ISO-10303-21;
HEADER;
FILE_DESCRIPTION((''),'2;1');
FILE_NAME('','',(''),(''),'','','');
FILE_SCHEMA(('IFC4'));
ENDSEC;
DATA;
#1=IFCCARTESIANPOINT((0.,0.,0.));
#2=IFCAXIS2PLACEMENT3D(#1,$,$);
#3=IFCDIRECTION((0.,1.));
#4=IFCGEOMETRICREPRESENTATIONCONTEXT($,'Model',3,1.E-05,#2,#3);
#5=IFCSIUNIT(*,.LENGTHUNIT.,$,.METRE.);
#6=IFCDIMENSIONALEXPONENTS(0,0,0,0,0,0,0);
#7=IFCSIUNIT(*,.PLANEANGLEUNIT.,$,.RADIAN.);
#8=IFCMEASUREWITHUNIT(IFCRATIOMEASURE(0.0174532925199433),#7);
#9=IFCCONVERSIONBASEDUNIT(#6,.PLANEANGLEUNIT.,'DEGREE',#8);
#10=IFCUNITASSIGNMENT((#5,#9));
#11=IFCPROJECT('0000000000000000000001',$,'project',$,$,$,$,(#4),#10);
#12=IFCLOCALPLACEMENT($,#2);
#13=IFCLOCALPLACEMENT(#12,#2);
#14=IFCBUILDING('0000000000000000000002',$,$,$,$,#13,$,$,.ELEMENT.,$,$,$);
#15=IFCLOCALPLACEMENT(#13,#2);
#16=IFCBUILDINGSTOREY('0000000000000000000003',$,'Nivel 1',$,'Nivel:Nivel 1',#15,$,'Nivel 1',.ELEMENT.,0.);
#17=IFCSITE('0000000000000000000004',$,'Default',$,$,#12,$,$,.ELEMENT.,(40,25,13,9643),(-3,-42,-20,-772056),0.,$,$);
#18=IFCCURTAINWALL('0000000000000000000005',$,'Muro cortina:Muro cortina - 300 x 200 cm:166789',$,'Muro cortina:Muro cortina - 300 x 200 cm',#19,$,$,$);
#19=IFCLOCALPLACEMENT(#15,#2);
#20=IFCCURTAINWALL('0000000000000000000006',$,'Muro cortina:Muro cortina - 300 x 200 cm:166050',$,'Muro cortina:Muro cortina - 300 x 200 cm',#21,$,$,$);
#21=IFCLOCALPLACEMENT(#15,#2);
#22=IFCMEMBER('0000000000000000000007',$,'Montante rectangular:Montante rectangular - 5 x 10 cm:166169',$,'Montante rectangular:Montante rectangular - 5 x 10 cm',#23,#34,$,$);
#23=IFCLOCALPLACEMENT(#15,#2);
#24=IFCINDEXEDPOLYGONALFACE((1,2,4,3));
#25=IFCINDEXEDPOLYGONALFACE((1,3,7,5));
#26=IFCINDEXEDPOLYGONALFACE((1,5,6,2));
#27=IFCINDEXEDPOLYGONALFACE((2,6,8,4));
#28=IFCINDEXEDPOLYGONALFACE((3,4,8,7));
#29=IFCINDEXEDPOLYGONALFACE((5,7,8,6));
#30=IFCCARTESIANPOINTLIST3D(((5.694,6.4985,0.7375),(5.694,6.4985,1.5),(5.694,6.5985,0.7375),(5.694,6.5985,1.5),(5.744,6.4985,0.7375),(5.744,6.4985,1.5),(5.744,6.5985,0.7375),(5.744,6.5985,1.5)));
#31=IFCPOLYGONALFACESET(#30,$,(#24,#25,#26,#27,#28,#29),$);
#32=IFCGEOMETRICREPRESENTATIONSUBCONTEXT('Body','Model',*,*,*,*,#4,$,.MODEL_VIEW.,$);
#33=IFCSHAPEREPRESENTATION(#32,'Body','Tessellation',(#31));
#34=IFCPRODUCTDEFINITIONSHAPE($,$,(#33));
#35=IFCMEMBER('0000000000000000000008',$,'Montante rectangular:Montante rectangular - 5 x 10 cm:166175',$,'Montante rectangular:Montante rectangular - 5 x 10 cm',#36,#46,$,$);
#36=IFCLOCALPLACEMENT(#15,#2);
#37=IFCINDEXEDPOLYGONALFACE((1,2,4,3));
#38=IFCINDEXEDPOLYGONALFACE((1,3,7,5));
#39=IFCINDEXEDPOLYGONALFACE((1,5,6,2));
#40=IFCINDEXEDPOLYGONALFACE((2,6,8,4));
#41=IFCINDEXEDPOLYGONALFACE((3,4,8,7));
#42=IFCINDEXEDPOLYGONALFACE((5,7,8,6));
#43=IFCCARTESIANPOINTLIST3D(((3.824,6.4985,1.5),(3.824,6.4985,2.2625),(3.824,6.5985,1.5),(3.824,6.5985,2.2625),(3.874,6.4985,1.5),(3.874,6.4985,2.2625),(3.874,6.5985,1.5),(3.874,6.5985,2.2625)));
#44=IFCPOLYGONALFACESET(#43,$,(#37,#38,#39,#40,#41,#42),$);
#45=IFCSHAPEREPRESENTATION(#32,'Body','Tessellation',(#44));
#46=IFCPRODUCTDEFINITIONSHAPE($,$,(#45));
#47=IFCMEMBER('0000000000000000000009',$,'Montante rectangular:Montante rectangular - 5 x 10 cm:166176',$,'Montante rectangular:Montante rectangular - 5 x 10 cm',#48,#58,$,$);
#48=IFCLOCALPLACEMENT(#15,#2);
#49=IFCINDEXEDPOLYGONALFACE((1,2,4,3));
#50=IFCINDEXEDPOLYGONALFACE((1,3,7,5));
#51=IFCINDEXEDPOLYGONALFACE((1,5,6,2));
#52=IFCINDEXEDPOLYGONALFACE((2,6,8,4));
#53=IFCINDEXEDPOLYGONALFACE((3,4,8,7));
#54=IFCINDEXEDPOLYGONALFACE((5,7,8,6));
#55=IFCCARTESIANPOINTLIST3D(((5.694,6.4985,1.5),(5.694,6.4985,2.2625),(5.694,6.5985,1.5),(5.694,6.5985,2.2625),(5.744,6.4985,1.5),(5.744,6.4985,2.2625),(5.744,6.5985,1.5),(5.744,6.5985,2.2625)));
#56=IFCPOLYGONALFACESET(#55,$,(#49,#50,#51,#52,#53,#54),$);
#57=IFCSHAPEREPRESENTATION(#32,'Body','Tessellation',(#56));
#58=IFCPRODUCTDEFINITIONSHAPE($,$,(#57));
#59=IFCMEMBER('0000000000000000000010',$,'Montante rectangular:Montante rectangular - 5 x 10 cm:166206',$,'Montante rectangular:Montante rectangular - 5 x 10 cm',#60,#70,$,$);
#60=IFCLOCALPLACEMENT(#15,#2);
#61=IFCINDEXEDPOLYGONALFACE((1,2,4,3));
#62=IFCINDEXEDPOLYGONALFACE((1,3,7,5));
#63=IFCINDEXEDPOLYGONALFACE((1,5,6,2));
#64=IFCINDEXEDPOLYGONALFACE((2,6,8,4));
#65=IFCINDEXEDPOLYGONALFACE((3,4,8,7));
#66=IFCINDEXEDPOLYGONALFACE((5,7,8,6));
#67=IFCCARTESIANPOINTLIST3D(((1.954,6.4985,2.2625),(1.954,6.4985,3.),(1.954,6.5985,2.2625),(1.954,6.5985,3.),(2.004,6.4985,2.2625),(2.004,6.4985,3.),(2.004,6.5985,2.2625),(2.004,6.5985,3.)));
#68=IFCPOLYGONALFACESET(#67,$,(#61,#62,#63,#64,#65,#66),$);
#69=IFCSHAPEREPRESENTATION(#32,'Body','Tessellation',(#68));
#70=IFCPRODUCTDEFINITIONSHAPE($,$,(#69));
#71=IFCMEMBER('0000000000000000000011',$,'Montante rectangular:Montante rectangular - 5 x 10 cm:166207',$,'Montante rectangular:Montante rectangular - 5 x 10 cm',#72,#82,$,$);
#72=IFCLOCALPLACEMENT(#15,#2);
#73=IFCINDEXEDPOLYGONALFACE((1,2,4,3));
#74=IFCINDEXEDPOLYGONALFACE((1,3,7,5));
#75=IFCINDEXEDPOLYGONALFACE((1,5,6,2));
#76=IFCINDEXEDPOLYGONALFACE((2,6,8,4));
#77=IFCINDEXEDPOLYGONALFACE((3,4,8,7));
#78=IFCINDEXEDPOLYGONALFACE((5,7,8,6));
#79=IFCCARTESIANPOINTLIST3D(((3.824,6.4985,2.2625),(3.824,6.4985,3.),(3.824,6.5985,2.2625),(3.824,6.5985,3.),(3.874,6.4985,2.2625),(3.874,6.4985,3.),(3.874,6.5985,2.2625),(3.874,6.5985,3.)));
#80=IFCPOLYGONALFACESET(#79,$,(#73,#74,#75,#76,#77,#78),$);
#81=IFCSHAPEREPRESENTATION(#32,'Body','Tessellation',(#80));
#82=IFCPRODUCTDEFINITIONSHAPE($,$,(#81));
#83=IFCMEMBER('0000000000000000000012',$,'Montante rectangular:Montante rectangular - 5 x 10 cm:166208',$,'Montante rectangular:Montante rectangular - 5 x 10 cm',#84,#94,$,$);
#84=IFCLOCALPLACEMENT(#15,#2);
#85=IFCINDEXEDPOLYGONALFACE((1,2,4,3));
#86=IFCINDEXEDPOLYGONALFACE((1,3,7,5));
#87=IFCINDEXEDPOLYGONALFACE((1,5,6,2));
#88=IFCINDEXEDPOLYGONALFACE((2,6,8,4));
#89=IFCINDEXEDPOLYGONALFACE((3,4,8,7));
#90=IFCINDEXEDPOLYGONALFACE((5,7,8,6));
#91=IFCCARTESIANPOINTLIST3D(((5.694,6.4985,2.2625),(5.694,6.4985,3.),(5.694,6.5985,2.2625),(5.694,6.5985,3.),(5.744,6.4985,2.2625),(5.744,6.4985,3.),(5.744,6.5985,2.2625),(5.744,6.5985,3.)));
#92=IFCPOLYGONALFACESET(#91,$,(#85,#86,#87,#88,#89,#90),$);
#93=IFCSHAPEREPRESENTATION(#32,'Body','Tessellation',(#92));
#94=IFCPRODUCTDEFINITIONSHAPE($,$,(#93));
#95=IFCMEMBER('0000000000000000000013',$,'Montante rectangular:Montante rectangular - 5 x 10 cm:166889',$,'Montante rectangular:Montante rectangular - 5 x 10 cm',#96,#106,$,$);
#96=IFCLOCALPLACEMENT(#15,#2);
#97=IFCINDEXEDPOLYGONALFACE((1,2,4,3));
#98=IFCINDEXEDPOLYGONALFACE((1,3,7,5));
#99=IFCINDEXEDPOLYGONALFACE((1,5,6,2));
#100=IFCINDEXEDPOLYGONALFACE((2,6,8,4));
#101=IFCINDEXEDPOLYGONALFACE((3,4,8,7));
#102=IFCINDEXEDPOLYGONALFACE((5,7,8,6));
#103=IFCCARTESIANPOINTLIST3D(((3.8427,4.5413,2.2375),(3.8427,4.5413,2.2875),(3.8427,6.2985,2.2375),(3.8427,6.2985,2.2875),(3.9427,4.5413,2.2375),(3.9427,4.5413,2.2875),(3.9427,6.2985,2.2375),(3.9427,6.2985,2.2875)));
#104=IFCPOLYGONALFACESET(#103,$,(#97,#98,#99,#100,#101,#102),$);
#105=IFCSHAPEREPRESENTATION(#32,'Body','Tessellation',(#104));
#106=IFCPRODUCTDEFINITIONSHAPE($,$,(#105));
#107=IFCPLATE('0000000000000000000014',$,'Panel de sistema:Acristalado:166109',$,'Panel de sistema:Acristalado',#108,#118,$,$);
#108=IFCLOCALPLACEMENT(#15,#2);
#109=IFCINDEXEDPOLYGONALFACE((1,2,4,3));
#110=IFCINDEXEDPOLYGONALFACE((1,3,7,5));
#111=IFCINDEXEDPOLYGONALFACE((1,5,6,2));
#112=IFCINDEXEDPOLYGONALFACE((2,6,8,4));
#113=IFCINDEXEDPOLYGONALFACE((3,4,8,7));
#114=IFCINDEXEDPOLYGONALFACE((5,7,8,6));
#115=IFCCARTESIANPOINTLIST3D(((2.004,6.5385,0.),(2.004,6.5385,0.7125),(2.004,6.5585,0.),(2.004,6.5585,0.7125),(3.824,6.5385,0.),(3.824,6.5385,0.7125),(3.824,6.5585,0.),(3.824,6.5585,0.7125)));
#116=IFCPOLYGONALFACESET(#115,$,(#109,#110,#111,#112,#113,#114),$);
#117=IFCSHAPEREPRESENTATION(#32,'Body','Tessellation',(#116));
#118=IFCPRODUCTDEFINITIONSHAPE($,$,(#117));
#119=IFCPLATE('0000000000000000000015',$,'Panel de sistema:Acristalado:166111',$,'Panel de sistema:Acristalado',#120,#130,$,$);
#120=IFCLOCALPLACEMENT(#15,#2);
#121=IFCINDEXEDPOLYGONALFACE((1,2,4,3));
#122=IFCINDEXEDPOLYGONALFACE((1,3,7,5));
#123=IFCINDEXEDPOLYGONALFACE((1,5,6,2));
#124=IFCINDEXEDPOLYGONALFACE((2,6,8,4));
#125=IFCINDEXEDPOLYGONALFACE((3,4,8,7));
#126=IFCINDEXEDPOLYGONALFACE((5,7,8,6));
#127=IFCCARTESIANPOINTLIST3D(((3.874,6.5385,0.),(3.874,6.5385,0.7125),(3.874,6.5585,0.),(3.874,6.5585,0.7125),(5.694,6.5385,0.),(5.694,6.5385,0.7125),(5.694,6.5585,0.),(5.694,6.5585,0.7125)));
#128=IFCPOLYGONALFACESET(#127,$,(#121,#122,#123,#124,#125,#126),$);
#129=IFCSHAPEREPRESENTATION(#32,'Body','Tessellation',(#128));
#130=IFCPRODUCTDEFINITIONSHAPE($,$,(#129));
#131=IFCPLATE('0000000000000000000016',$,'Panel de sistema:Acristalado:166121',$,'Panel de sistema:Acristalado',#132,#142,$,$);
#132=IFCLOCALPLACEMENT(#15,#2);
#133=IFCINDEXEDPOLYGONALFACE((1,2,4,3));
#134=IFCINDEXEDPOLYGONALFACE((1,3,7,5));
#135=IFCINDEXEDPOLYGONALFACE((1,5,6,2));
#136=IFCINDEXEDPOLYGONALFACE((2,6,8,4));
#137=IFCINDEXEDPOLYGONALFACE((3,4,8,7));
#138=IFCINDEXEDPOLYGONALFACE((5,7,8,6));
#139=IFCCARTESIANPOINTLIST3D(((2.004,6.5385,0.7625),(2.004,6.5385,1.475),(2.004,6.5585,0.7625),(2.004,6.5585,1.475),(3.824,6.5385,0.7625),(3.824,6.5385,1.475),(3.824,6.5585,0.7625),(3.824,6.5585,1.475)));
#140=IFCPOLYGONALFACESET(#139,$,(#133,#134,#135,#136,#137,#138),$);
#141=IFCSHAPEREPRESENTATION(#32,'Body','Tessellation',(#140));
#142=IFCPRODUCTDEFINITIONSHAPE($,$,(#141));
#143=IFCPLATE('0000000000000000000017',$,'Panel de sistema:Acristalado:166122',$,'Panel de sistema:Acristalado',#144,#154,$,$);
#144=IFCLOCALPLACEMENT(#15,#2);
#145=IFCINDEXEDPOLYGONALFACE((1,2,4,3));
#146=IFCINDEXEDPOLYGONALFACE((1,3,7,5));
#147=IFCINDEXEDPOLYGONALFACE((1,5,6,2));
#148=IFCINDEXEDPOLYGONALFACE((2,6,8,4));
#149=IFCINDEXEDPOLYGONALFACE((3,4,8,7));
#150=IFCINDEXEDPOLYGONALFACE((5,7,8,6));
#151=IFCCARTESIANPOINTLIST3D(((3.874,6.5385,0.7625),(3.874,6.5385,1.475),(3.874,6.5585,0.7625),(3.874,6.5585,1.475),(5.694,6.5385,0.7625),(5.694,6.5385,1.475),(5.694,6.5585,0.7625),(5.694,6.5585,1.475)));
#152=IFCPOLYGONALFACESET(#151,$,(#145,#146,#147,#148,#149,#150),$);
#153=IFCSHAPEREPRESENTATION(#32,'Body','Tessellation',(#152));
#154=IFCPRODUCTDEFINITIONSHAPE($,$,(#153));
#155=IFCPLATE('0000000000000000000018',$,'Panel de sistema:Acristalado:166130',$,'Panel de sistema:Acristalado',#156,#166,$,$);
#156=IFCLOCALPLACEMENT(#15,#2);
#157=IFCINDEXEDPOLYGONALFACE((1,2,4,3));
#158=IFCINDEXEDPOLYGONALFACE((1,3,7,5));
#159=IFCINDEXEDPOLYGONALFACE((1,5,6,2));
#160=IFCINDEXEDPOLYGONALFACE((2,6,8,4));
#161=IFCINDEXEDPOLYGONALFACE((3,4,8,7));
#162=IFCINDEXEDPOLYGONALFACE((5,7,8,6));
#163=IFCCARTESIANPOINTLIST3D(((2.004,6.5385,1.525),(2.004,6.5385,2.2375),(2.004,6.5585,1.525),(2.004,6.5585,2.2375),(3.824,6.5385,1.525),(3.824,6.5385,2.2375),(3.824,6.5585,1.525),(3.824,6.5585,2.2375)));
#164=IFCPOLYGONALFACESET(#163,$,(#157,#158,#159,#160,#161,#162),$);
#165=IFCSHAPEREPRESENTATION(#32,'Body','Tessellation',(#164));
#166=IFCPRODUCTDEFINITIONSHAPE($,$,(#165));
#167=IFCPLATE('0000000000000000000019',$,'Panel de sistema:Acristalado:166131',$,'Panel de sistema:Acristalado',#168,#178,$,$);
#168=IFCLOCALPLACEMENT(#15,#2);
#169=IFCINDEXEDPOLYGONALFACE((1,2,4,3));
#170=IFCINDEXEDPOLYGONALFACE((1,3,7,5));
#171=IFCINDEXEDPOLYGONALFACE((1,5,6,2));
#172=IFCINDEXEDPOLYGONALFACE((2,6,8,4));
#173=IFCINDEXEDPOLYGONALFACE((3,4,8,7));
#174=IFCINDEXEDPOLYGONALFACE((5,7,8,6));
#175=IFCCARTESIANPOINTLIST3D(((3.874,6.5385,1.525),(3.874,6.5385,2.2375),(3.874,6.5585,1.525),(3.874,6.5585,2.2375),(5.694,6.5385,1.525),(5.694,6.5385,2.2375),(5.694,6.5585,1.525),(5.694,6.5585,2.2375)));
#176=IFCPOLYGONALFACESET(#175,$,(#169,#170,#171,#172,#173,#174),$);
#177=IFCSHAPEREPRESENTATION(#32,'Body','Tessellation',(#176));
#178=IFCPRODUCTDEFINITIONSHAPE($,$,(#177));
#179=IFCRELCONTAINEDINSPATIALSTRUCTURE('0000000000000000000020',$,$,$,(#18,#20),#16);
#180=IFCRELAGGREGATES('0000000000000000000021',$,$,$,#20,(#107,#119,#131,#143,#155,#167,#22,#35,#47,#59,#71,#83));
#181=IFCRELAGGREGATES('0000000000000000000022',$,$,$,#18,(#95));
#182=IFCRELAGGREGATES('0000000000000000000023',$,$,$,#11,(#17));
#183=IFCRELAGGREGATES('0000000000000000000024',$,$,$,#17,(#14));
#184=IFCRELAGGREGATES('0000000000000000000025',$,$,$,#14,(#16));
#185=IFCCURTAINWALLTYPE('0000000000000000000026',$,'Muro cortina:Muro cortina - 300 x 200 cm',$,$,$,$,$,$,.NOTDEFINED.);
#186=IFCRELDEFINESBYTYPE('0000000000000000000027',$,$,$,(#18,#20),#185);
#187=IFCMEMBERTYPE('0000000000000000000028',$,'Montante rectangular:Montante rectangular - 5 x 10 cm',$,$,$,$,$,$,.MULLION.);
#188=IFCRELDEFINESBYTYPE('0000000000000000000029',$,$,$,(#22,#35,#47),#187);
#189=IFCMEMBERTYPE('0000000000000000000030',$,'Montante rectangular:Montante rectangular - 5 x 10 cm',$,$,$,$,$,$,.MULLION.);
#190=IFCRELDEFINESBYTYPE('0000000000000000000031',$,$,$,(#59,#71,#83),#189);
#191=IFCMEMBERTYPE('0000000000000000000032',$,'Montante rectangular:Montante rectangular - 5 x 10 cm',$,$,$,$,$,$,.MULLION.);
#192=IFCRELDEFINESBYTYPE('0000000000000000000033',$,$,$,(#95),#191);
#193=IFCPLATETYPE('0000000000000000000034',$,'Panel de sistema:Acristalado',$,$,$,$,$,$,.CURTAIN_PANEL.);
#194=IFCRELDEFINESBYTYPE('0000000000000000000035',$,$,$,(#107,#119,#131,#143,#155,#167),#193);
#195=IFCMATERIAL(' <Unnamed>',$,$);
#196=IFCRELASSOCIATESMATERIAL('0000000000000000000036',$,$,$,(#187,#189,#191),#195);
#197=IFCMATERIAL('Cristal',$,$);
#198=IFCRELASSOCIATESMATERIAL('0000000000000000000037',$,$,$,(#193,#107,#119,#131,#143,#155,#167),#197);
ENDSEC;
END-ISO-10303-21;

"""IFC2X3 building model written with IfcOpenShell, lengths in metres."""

from ifc_helpers import new_model, entity, si_unit, converted_unit, direction, frame, origin, origin_2d_with_axis, place, context, subcontext, project, spatial, rectangle, extrude, source, transform, mapped, material, type_object, type_shapes, element, aggregate, save


model = new_model("IFC2X3")

# Units and contexts
model_context = context("Model", 3, precision=1e-05, world=origin(), true_north=direction((0.0, 1.0)))
body_context = subcontext(model_context, "Body", "Model", "MODEL_VIEW")
ifc_project = project(units=[si_unit("LENGTHUNIT", "METRE"), converted_unit("PLANEANGLEUNIT", "DEGREE", entity("IfcRatioMeasure", 0.0174532925199433), si_unit("PLANEANGLEUNIT", "RADIAN"), dimensions=[0, 0, 0, 0, 0, 0, 0])], contexts=[model_context])

# Site, building, storey
site_placement = place(None, origin())
site = spatial("IfcSite", under=ifc_project, at=site_placement, Name="Default", CompositionType="ELEMENT", RefLatitude=(40, 25, 13, 9643), RefLongitude=(-3, -42, -20, -772056), RefElevation=0.0)
building_placement = place(site_placement, origin())
building = spatial("IfcBuilding", under=site, at=building_placement, CompositionType="ELEMENT")
storey_placement = place(building_placement, origin())
storey = spatial("IfcBuildingStorey", under=building, at=storey_placement, Name="Nivel 1", ObjectType="Nivel:Nivel 1", LongName="Nivel 1", CompositionType="ELEMENT", Elevation=0.0)

# Curtain walls, members
curtain_wall_type = type_object("IfcCurtainWallType", Name="Muro cortina:Muro cortina - 300 x 200 cm", PredefinedType="NOTDEFINED")
curtain_wall_1_placement = place(storey_placement, origin())
curtain_wall_1 = element("IfcCurtainWall", 1, at=curtain_wall_1_placement, inside=storey, type_object=curtain_wall_type, Name="Muro cortina:Muro cortina - 300 x 200 cm:166789", ObjectType="Muro cortina:Muro cortina - 300 x 200 cm")
ifc_material_1 = material(Name=" <Unnamed>")
curtain_wall_2_placement = place(storey_placement, origin())
curtain_wall_2 = element("IfcCurtainWall", 2, at=curtain_wall_2_placement, inside=storey, type_object=curtain_wall_type, Name="Muro cortina:Muro cortina - 300 x 200 cm:166050", ObjectType="Muro cortina:Muro cortina - 300 x 200 cm")
member_type_1 = type_object("IfcMemberType", Name="Montante rectangular:Montante rectangular - 5 x 10 cm", PredefinedType="MULLION", material=ifc_material_1)
shared_shape_1 = source(origin(), body_context, "Body", "SweptSolid", [
    extrude(rectangle(XDim=0.1, YDim=0.05, at=origin_2d_with_axis()), frame((0.0, 0.0, -0.7625), z_axis=(0.0, 0.0, 1.0), x_axis=(0.0, -1.0, 0.0)), (0.0, 0.0, 1.0), 0.7625),
])
type_shapes(member_type_1, [shared_shape_1])
member_1_placement = place(storey_placement, frame((5.719, 6.5485, 0.7375), z_axis=(0.0, 0.0, -1.0), x_axis=(1.0, 0.0, 0.0)))
member_1 = element("IfcMember", 3, at=member_1_placement, type_object=member_type_1, Name="Montante rectangular:Montante rectangular - 5 x 10 cm:166169", ObjectType="Montante rectangular:Montante rectangular - 5 x 10 cm", context=body_context, shape_type="MappedRepresentation", body=[
    mapped(shared_shape_1, transform((0.0, 0.0, 0.0), scale=1.0)),
])
member_2_placement = place(storey_placement, frame((3.849, 6.5485, 1.5), z_axis=(0.0, 0.0, -1.0), x_axis=(1.0, 0.0, 0.0)))
member_2 = element("IfcMember", 4, at=member_2_placement, type_object=member_type_1, Name="Montante rectangular:Montante rectangular - 5 x 10 cm:166175", ObjectType="Montante rectangular:Montante rectangular - 5 x 10 cm", context=body_context, shape_type="MappedRepresentation", body=[
    mapped(shared_shape_1, transform((0.0, 0.0, 0.0), scale=1.0)),
])
member_3_placement = place(storey_placement, frame((5.719, 6.5485, 1.5), z_axis=(0.0, 0.0, -1.0), x_axis=(1.0, 0.0, 0.0)))
member_3 = element("IfcMember", 5, at=member_3_placement, type_object=member_type_1, Name="Montante rectangular:Montante rectangular - 5 x 10 cm:166176", ObjectType="Montante rectangular:Montante rectangular - 5 x 10 cm", context=body_context, shape_type="MappedRepresentation", body=[
    mapped(shared_shape_1, transform((0.0, 0.0, 0.0), scale=1.0)),
])
member_type_2 = type_object("IfcMemberType", Name="Montante rectangular:Montante rectangular - 5 x 10 cm", PredefinedType="MULLION", material=ifc_material_1)
shared_shape_2 = source(origin(), body_context, "Body", "SweptSolid", [
    extrude(rectangle(XDim=0.1, YDim=0.05, at=origin_2d_with_axis()), frame((0.0, 0.0, -0.7375), z_axis=(0.0, 0.0, 1.0), x_axis=(0.0, -1.0, 0.0)), (0.0, 0.0, 1.0), 0.7375),
])
type_shapes(member_type_2, [shared_shape_2])
member_4_placement = place(storey_placement, frame((1.979, 6.5485, 2.2625), z_axis=(0.0, 0.0, -1.0), x_axis=(1.0, 0.0, 0.0)))
member_4 = element("IfcMember", 6, at=member_4_placement, type_object=member_type_2, Name="Montante rectangular:Montante rectangular - 5 x 10 cm:166206", ObjectType="Montante rectangular:Montante rectangular - 5 x 10 cm", context=body_context, shape_type="MappedRepresentation", body=[
    mapped(shared_shape_2, transform((0.0, 0.0, 0.0), scale=1.0)),
])
member_5_placement = place(storey_placement, frame((3.849, 6.5485, 2.2625), z_axis=(0.0, 0.0, -1.0), x_axis=(1.0, 0.0, 0.0)))
member_5 = element("IfcMember", 7, at=member_5_placement, type_object=member_type_2, Name="Montante rectangular:Montante rectangular - 5 x 10 cm:166207", ObjectType="Montante rectangular:Montante rectangular - 5 x 10 cm", context=body_context, shape_type="MappedRepresentation", body=[
    mapped(shared_shape_2, transform((0.0, 0.0, 0.0), scale=1.0)),
])
member_6_placement = place(storey_placement, frame((5.719, 6.5485, 2.2625), z_axis=(0.0, 0.0, -1.0), x_axis=(1.0, 0.0, 0.0)))
member_6 = element("IfcMember", 8, at=member_6_placement, type_object=member_type_2, Name="Montante rectangular:Montante rectangular - 5 x 10 cm:166208", ObjectType="Montante rectangular:Montante rectangular - 5 x 10 cm", context=body_context, shape_type="MappedRepresentation", body=[
    mapped(shared_shape_2, transform((0.0, 0.0, 0.0), scale=1.0)),
])

# Member
member_type_3 = type_object("IfcMemberType", Name="Montante rectangular:Montante rectangular - 5 x 10 cm", PredefinedType="MULLION", material=ifc_material_1)
shared_shape_3 = source(origin(), body_context, "Body", "SweptSolid", [
    extrude(rectangle(XDim=0.1, YDim=0.05, at=origin_2d_with_axis()), frame((0.0, 0.0, -1.7571), z_axis=(0.0, 0.0, 1.0), x_axis=(0.0, -1.0, 0.0)), (0.0, 0.0, 1.0), 1.7571),
])
type_shapes(member_type_3, [shared_shape_3])
member_7_placement = place(storey_placement, frame((3.8927, 4.5413, 2.2625), z_axis=(0.0, -1.0, 0.0), x_axis=(0.0, 0.0, 1.0)))
member_7 = element("IfcMember", 9, at=member_7_placement, type_object=member_type_3, Name="Montante rectangular:Montante rectangular - 5 x 10 cm:166889", ObjectType="Montante rectangular:Montante rectangular - 5 x 10 cm", context=body_context, shape_type="MappedRepresentation", body=[
    mapped(shared_shape_3, transform((0.0, 0.0, 0.0), scale=1.0)),
])

# Plates
ifc_material_2 = material(Name="Cristal")
plate_type_1 = type_object("IfcPlateType", Name="Panel de sistema:Acristalado", PredefinedType="CURTAIN_PANEL", material=ifc_material_2)
shared_shape_4 = source(origin(), body_context, "Body", "SweptSolid", [
    extrude(rectangle(XDim=0.02, YDim=1.82, at=origin_2d_with_axis()), frame((0.0, 0.0, 0.0), z_axis=(0.0, 0.0, 1.0), x_axis=(0.0, 1.0, 0.0)), (0.0, 0.0, 1.0), 0.7125),
])
type_shapes(plate_type_1, [shared_shape_4])
plate_1_placement = place(curtain_wall_2_placement, frame((2.914, 6.5485, 0.0)))
plate_1 = element("IfcPlate", 10, at=plate_1_placement, type_object=plate_type_1, material=ifc_material_2, Name="Panel de sistema:Acristalado:166109", ObjectType="Panel de sistema:Acristalado", context=body_context, shape_type="MappedRepresentation", body=[
    mapped(shared_shape_4, transform((0.0, 0.0, 0.0), scale=1.0)),
])
plate_2_placement = place(curtain_wall_2_placement, frame((4.784, 6.5485, 0.0)))
plate_2 = element("IfcPlate", 11, at=plate_2_placement, type_object=plate_type_1, material=ifc_material_2, Name="Panel de sistema:Acristalado:166111", ObjectType="Panel de sistema:Acristalado", context=body_context, shape_type="MappedRepresentation", body=[
    mapped(shared_shape_4, transform((0.0, 0.0, 0.0), scale=1.0)),
])
plate_3_placement = place(curtain_wall_2_placement, frame((2.914, 6.5485, 0.7625)))
plate_3 = element("IfcPlate", 12, at=plate_3_placement, type_object=plate_type_1, material=ifc_material_2, Name="Panel de sistema:Acristalado:166121", ObjectType="Panel de sistema:Acristalado", context=body_context, shape_type="MappedRepresentation", body=[
    mapped(shared_shape_4, transform((0.0, 0.0, 0.0), scale=1.0)),
])
plate_4_placement = place(curtain_wall_2_placement, frame((4.784, 6.5485, 0.7625)))
plate_4 = element("IfcPlate", 13, at=plate_4_placement, type_object=plate_type_1, material=ifc_material_2, Name="Panel de sistema:Acristalado:166122", ObjectType="Panel de sistema:Acristalado", context=body_context, shape_type="MappedRepresentation", body=[
    mapped(shared_shape_4, transform((0.0, 0.0, 0.0), scale=1.0)),
])
plate_5_placement = place(curtain_wall_2_placement, frame((2.914, 6.5485, 1.525)))
plate_5 = element("IfcPlate", 14, at=plate_5_placement, type_object=plate_type_1, material=ifc_material_2, Name="Panel de sistema:Acristalado:166130", ObjectType="Panel de sistema:Acristalado", context=body_context, shape_type="MappedRepresentation", body=[
    mapped(shared_shape_4, transform((0.0, 0.0, 0.0), scale=1.0)),
])
plate_6_placement = place(curtain_wall_2_placement, frame((4.784, 6.5485, 1.525)))
plate_6 = element("IfcPlate", 15, at=plate_6_placement, type_object=plate_type_1, material=ifc_material_2, Name="Panel de sistema:Acristalado:166131", ObjectType="Panel de sistema:Acristalado", context=body_context, shape_type="MappedRepresentation", body=[
    mapped(shared_shape_4, transform((0.0, 0.0, 0.0), scale=1.0)),
])
aggregate(curtain_wall_2, [plate_1, plate_2, plate_3, plate_4, plate_5, plate_6, member_1, member_2, member_3, member_4, member_5, member_6])
aggregate(curtain_wall_1, [member_7])

save(model, "model.ifc")
